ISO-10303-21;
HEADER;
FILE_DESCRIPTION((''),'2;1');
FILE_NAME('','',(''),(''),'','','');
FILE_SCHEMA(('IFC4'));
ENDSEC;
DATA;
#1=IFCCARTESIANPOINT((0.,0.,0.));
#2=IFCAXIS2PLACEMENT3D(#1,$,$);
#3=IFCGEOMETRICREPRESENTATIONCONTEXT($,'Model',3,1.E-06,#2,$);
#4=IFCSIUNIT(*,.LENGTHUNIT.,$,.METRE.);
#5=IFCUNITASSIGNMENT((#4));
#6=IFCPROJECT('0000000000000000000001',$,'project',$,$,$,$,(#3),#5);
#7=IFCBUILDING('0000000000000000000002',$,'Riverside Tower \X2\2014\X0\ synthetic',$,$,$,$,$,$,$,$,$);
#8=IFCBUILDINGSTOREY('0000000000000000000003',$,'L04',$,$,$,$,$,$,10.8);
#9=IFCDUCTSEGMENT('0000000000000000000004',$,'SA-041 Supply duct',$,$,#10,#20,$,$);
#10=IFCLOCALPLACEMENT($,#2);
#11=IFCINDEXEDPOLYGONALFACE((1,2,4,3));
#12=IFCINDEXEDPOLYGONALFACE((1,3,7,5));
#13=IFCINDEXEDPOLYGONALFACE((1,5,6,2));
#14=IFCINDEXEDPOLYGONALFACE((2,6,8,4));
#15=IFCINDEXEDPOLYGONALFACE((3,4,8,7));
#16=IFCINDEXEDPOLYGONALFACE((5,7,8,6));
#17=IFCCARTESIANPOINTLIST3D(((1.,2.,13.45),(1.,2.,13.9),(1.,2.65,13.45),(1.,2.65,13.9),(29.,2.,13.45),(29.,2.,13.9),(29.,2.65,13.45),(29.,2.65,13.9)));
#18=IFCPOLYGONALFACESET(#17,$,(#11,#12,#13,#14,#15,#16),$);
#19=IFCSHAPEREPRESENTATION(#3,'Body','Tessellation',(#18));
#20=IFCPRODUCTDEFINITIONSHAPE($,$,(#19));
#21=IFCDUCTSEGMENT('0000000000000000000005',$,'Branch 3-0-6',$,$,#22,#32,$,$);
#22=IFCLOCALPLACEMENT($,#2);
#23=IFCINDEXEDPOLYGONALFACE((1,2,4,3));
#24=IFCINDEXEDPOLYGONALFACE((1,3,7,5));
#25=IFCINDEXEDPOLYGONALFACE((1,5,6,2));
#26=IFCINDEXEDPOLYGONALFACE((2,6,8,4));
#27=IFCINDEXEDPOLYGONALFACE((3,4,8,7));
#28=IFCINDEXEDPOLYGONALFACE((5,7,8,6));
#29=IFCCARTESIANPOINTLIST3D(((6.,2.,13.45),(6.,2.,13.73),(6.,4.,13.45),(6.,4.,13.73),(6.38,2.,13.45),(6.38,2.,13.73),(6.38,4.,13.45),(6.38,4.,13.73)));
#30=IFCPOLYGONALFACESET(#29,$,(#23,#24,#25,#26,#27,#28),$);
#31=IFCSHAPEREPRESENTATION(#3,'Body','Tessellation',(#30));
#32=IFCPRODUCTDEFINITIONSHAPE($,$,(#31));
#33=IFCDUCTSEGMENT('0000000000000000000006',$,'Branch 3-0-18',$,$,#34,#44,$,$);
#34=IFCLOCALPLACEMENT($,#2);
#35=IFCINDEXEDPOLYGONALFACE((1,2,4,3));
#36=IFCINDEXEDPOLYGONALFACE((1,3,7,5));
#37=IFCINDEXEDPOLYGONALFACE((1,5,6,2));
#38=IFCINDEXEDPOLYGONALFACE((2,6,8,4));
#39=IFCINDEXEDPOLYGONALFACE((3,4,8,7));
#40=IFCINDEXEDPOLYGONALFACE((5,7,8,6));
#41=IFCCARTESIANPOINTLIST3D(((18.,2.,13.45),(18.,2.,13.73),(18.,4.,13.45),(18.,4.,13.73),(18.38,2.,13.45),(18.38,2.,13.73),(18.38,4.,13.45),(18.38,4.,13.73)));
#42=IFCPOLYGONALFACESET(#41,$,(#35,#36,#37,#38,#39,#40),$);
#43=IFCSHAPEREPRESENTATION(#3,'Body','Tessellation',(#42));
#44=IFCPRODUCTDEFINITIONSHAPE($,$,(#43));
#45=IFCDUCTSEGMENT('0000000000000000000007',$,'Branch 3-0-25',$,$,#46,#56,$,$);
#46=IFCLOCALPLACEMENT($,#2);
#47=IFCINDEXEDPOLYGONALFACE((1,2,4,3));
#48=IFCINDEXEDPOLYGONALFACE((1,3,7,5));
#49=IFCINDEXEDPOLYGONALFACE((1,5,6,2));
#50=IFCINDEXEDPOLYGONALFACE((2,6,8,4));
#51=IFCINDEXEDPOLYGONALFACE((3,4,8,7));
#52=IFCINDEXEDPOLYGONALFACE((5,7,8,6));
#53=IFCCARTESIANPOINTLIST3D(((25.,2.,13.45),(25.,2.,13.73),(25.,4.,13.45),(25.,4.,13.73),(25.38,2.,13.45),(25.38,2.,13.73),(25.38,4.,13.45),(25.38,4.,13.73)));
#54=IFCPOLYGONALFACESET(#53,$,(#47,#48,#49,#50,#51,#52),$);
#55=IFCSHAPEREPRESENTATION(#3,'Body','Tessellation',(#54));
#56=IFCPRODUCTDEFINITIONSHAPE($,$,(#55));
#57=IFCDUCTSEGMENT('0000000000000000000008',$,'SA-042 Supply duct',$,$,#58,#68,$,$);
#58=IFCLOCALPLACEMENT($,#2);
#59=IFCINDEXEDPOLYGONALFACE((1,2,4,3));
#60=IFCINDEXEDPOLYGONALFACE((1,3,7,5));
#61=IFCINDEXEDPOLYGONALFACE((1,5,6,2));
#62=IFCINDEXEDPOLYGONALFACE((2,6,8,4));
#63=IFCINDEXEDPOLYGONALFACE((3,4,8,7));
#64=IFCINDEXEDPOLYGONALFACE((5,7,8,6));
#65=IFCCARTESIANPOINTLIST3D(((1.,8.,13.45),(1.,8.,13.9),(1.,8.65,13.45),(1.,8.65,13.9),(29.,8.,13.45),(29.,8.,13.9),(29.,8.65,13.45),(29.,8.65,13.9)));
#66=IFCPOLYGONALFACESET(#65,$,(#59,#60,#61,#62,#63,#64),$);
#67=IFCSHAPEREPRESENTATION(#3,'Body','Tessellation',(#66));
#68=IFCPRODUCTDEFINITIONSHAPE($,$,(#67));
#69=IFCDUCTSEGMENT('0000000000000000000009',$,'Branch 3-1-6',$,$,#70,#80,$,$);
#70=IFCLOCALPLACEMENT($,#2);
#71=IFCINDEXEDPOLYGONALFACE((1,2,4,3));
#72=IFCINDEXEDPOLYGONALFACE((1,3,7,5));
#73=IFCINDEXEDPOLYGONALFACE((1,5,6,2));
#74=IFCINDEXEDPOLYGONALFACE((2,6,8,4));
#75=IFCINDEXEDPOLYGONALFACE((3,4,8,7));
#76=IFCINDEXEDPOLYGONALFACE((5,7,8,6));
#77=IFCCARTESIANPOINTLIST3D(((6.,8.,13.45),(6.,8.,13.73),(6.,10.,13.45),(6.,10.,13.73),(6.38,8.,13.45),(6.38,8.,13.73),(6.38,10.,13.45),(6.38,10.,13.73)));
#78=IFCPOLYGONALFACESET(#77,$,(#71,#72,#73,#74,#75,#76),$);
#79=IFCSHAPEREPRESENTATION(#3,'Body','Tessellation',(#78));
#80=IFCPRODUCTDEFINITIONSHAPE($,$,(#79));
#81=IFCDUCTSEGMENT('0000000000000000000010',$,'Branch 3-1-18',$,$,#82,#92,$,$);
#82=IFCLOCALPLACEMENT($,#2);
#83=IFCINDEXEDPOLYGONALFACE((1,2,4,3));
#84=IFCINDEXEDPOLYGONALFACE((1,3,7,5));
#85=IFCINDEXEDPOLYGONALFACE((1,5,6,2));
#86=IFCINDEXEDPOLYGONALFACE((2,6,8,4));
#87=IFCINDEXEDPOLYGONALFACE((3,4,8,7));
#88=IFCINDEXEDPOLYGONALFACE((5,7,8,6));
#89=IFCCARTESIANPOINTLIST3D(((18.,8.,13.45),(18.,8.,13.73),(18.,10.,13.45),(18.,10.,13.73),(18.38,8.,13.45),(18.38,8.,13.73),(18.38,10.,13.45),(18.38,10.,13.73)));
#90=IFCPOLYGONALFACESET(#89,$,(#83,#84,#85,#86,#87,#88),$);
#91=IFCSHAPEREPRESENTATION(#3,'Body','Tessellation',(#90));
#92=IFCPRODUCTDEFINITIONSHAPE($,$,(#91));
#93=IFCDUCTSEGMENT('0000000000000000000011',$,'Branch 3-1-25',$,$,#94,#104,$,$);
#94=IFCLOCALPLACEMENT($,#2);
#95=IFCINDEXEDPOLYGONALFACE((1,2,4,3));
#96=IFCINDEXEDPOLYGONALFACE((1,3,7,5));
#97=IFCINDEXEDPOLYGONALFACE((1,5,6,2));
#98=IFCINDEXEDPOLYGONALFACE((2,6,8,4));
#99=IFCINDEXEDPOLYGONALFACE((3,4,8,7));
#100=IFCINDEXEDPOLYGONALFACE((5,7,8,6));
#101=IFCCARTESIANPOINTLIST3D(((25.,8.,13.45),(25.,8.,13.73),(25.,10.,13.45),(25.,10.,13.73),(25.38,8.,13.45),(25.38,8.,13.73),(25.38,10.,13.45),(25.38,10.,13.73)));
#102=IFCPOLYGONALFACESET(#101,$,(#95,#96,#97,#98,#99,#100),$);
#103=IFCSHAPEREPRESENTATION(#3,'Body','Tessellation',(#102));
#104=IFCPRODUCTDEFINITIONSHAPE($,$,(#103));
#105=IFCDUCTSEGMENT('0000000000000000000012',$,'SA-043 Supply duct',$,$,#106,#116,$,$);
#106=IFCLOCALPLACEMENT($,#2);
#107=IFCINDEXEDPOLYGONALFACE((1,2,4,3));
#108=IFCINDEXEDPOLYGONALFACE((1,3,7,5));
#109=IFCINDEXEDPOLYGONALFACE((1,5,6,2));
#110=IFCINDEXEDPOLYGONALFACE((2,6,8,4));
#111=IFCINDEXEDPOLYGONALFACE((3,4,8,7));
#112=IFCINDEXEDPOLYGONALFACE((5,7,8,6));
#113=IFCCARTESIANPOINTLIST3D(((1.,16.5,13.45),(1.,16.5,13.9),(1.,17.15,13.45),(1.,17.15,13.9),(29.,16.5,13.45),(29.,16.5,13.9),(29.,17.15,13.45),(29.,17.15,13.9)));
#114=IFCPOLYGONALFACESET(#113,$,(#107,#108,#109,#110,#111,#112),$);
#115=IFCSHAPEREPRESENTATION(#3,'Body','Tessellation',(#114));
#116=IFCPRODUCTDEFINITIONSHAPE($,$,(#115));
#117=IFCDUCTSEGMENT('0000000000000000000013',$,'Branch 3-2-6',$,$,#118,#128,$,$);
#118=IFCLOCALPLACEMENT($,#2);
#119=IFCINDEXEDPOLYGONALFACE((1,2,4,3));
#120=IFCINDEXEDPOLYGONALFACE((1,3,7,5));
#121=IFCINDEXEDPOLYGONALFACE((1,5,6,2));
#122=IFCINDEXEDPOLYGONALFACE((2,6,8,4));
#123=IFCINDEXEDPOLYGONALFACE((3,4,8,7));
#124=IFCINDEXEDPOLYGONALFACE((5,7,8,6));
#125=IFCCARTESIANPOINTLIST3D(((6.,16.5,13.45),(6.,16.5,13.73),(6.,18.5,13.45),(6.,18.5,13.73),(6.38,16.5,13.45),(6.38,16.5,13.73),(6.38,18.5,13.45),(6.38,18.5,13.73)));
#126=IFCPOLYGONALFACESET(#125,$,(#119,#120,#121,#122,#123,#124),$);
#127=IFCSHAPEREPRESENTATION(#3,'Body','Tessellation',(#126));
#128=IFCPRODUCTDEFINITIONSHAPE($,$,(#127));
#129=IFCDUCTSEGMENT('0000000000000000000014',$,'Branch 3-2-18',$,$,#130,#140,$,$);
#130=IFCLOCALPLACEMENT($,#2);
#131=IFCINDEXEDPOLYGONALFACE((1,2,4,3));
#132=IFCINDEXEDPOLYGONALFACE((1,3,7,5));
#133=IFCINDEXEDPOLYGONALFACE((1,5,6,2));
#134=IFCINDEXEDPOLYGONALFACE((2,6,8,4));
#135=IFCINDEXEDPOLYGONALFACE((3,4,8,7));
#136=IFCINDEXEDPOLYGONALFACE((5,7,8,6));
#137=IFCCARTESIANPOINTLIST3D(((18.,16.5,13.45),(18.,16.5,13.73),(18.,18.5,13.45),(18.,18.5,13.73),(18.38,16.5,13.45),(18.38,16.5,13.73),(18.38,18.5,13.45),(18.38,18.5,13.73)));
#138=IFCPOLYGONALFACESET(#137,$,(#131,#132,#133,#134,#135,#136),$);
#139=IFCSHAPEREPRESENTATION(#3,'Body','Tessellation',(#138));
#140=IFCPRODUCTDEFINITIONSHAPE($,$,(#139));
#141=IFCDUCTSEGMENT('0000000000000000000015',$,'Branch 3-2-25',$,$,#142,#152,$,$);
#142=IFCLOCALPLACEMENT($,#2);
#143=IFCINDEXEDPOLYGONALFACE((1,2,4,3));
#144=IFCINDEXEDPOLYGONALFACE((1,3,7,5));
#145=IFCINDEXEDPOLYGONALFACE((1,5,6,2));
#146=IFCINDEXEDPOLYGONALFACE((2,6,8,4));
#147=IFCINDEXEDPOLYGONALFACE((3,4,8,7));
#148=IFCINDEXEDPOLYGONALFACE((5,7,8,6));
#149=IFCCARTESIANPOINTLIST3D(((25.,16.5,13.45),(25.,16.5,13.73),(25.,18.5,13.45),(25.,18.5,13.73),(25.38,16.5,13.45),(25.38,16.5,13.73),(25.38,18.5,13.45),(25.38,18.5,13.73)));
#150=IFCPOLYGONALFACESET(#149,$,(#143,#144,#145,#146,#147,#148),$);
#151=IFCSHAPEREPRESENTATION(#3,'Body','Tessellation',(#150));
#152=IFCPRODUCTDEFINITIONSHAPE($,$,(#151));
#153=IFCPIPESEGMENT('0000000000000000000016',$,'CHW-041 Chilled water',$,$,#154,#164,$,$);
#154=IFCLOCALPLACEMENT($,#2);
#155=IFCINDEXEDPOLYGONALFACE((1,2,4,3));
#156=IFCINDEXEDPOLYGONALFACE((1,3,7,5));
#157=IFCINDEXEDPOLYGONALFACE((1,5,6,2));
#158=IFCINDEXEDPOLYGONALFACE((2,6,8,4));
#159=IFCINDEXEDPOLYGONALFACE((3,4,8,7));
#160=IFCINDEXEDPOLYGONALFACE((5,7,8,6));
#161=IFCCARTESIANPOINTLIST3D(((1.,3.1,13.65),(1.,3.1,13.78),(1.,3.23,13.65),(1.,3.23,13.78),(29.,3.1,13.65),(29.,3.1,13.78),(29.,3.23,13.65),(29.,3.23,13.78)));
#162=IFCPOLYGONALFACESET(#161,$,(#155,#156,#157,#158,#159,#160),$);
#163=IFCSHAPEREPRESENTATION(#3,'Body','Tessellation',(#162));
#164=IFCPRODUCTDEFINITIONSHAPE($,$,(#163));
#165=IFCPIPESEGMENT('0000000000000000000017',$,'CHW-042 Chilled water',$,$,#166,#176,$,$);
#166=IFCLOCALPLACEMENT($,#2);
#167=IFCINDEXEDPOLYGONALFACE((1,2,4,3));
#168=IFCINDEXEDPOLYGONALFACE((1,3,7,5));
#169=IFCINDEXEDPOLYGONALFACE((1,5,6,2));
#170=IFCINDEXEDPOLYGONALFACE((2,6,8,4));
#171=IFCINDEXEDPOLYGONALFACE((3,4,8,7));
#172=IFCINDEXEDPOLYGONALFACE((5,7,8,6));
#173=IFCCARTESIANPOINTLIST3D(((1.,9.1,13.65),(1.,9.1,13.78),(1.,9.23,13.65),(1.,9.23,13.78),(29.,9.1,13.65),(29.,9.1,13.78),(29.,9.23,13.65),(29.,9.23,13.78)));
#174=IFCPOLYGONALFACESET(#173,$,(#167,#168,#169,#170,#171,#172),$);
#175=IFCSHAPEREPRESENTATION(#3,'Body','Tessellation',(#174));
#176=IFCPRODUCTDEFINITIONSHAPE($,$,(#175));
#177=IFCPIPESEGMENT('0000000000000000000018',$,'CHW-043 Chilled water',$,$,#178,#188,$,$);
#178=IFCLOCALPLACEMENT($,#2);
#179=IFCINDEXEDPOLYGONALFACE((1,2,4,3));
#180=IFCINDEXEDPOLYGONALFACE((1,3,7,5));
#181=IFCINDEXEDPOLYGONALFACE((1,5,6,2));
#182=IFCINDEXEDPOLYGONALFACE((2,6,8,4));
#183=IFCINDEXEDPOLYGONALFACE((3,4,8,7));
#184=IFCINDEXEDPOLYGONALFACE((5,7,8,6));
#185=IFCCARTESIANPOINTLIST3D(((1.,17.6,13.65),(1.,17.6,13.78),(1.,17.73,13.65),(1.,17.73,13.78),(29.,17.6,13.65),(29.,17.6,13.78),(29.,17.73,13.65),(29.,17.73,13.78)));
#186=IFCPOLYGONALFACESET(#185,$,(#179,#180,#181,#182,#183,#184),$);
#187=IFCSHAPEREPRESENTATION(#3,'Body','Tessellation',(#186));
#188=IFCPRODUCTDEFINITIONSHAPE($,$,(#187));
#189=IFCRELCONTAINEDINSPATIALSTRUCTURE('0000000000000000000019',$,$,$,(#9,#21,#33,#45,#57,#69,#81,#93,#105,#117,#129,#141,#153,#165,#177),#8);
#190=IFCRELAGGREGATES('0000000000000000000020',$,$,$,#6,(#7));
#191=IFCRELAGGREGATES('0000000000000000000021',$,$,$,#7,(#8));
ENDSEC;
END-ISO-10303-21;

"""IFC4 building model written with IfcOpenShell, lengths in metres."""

from ifc_helpers import new_model, si_unit, frame, origin, place, context, project, spatial, rectangle, extrude, element, save


model = new_model("IFC4")

# Units and contexts
model_context = context("Model", 3, precision=1e-06, world=origin())
ifc_project = project(units=[si_unit("LENGTHUNIT", "METRE")], contexts=[model_context])

# Building, storey
building = spatial("IfcBuilding", under=ifc_project, Name="Riverside Tower — synthetic")
storey = spatial("IfcBuildingStorey", under=building, Name="L04", Elevation=10.8)

# Duct segments
duct_segment_1_placement = place(None, frame((15.0, 2.325, 13.45)))
element("IfcDuctSegment", 1, at=duct_segment_1_placement, inside=storey, Name="SA-041 Supply duct", context=model_context, shape_type="SweptSolid", body=[
    extrude(rectangle(XDim=28.0, YDim=0.65), origin(), (0.0, 0.0, 1.0), 0.45),
])
for number, where, name in (
    (2, (6.19, 3.0, 13.45), "Branch 3-0-6"),
    (3, (18.19, 3.0, 13.45), "Branch 3-0-18"),
    (4, (25.19, 3.0, 13.45), "Branch 3-0-25"),
):
    element("IfcDuctSegment", number, at=place(None, frame(where)), inside=storey, Name=name, context=model_context, shape_type="SweptSolid", body=[
        extrude(rectangle(XDim=0.38, YDim=2.0), origin(), (0.0, 0.0, 1.0), 0.28),
    ])
duct_segment_2_placement = place(None, frame((15.0, 8.325, 13.45)))
element("IfcDuctSegment", 5, at=duct_segment_2_placement, inside=storey, Name="SA-042 Supply duct", context=model_context, shape_type="SweptSolid", body=[
    extrude(rectangle(XDim=28.0, YDim=0.65), origin(), (0.0, 0.0, 1.0), 0.45),
])
for number, where, name in (
    (6, (6.19, 9.0, 13.45), "Branch 3-1-6"),
    (7, (18.19, 9.0, 13.45), "Branch 3-1-18"),
    (8, (25.19, 9.0, 13.45), "Branch 3-1-25"),
):
    element("IfcDuctSegment", number, at=place(None, frame(where)), inside=storey, Name=name, context=model_context, shape_type="SweptSolid", body=[
        extrude(rectangle(XDim=0.38, YDim=2.0), origin(), (0.0, 0.0, 1.0), 0.28),
    ])
duct_segment_3_placement = place(None, frame((15.0, 16.825, 13.45)))
element("IfcDuctSegment", 9, at=duct_segment_3_placement, inside=storey, Name="SA-043 Supply duct", context=model_context, shape_type="SweptSolid", body=[
    extrude(rectangle(XDim=28.0, YDim=0.65), origin(), (0.0, 0.0, 1.0), 0.45),
])
for number, where, name in (
    (10, (6.19, 17.5, 13.45), "Branch 3-2-6"),
    (11, (18.19, 17.5, 13.45), "Branch 3-2-18"),
    (12, (25.19, 17.5, 13.45), "Branch 3-2-25"),
):
    element("IfcDuctSegment", number, at=place(None, frame(where)), inside=storey, Name=name, context=model_context, shape_type="SweptSolid", body=[
        extrude(rectangle(XDim=0.38, YDim=2.0), origin(), (0.0, 0.0, 1.0), 0.28),
    ])

# Pipe segments
for number, where, name in (
    (13, (15.0, 3.165, 13.65), "CHW-041 Chilled water"),
    (14, (15.0, 9.165, 13.65), "CHW-042 Chilled water"),
    (15, (15.0, 17.665, 13.65), "CHW-043 Chilled water"),
):
    element("IfcPipeSegment", number, at=place(None, frame(where)), inside=storey, Name=name, context=model_context, shape_type="SweptSolid", body=[
        extrude(rectangle(XDim=28.0, YDim=0.13), origin(), (0.0, 0.0, 1.0), 0.13),
    ])

save(model, "model.ifc")
